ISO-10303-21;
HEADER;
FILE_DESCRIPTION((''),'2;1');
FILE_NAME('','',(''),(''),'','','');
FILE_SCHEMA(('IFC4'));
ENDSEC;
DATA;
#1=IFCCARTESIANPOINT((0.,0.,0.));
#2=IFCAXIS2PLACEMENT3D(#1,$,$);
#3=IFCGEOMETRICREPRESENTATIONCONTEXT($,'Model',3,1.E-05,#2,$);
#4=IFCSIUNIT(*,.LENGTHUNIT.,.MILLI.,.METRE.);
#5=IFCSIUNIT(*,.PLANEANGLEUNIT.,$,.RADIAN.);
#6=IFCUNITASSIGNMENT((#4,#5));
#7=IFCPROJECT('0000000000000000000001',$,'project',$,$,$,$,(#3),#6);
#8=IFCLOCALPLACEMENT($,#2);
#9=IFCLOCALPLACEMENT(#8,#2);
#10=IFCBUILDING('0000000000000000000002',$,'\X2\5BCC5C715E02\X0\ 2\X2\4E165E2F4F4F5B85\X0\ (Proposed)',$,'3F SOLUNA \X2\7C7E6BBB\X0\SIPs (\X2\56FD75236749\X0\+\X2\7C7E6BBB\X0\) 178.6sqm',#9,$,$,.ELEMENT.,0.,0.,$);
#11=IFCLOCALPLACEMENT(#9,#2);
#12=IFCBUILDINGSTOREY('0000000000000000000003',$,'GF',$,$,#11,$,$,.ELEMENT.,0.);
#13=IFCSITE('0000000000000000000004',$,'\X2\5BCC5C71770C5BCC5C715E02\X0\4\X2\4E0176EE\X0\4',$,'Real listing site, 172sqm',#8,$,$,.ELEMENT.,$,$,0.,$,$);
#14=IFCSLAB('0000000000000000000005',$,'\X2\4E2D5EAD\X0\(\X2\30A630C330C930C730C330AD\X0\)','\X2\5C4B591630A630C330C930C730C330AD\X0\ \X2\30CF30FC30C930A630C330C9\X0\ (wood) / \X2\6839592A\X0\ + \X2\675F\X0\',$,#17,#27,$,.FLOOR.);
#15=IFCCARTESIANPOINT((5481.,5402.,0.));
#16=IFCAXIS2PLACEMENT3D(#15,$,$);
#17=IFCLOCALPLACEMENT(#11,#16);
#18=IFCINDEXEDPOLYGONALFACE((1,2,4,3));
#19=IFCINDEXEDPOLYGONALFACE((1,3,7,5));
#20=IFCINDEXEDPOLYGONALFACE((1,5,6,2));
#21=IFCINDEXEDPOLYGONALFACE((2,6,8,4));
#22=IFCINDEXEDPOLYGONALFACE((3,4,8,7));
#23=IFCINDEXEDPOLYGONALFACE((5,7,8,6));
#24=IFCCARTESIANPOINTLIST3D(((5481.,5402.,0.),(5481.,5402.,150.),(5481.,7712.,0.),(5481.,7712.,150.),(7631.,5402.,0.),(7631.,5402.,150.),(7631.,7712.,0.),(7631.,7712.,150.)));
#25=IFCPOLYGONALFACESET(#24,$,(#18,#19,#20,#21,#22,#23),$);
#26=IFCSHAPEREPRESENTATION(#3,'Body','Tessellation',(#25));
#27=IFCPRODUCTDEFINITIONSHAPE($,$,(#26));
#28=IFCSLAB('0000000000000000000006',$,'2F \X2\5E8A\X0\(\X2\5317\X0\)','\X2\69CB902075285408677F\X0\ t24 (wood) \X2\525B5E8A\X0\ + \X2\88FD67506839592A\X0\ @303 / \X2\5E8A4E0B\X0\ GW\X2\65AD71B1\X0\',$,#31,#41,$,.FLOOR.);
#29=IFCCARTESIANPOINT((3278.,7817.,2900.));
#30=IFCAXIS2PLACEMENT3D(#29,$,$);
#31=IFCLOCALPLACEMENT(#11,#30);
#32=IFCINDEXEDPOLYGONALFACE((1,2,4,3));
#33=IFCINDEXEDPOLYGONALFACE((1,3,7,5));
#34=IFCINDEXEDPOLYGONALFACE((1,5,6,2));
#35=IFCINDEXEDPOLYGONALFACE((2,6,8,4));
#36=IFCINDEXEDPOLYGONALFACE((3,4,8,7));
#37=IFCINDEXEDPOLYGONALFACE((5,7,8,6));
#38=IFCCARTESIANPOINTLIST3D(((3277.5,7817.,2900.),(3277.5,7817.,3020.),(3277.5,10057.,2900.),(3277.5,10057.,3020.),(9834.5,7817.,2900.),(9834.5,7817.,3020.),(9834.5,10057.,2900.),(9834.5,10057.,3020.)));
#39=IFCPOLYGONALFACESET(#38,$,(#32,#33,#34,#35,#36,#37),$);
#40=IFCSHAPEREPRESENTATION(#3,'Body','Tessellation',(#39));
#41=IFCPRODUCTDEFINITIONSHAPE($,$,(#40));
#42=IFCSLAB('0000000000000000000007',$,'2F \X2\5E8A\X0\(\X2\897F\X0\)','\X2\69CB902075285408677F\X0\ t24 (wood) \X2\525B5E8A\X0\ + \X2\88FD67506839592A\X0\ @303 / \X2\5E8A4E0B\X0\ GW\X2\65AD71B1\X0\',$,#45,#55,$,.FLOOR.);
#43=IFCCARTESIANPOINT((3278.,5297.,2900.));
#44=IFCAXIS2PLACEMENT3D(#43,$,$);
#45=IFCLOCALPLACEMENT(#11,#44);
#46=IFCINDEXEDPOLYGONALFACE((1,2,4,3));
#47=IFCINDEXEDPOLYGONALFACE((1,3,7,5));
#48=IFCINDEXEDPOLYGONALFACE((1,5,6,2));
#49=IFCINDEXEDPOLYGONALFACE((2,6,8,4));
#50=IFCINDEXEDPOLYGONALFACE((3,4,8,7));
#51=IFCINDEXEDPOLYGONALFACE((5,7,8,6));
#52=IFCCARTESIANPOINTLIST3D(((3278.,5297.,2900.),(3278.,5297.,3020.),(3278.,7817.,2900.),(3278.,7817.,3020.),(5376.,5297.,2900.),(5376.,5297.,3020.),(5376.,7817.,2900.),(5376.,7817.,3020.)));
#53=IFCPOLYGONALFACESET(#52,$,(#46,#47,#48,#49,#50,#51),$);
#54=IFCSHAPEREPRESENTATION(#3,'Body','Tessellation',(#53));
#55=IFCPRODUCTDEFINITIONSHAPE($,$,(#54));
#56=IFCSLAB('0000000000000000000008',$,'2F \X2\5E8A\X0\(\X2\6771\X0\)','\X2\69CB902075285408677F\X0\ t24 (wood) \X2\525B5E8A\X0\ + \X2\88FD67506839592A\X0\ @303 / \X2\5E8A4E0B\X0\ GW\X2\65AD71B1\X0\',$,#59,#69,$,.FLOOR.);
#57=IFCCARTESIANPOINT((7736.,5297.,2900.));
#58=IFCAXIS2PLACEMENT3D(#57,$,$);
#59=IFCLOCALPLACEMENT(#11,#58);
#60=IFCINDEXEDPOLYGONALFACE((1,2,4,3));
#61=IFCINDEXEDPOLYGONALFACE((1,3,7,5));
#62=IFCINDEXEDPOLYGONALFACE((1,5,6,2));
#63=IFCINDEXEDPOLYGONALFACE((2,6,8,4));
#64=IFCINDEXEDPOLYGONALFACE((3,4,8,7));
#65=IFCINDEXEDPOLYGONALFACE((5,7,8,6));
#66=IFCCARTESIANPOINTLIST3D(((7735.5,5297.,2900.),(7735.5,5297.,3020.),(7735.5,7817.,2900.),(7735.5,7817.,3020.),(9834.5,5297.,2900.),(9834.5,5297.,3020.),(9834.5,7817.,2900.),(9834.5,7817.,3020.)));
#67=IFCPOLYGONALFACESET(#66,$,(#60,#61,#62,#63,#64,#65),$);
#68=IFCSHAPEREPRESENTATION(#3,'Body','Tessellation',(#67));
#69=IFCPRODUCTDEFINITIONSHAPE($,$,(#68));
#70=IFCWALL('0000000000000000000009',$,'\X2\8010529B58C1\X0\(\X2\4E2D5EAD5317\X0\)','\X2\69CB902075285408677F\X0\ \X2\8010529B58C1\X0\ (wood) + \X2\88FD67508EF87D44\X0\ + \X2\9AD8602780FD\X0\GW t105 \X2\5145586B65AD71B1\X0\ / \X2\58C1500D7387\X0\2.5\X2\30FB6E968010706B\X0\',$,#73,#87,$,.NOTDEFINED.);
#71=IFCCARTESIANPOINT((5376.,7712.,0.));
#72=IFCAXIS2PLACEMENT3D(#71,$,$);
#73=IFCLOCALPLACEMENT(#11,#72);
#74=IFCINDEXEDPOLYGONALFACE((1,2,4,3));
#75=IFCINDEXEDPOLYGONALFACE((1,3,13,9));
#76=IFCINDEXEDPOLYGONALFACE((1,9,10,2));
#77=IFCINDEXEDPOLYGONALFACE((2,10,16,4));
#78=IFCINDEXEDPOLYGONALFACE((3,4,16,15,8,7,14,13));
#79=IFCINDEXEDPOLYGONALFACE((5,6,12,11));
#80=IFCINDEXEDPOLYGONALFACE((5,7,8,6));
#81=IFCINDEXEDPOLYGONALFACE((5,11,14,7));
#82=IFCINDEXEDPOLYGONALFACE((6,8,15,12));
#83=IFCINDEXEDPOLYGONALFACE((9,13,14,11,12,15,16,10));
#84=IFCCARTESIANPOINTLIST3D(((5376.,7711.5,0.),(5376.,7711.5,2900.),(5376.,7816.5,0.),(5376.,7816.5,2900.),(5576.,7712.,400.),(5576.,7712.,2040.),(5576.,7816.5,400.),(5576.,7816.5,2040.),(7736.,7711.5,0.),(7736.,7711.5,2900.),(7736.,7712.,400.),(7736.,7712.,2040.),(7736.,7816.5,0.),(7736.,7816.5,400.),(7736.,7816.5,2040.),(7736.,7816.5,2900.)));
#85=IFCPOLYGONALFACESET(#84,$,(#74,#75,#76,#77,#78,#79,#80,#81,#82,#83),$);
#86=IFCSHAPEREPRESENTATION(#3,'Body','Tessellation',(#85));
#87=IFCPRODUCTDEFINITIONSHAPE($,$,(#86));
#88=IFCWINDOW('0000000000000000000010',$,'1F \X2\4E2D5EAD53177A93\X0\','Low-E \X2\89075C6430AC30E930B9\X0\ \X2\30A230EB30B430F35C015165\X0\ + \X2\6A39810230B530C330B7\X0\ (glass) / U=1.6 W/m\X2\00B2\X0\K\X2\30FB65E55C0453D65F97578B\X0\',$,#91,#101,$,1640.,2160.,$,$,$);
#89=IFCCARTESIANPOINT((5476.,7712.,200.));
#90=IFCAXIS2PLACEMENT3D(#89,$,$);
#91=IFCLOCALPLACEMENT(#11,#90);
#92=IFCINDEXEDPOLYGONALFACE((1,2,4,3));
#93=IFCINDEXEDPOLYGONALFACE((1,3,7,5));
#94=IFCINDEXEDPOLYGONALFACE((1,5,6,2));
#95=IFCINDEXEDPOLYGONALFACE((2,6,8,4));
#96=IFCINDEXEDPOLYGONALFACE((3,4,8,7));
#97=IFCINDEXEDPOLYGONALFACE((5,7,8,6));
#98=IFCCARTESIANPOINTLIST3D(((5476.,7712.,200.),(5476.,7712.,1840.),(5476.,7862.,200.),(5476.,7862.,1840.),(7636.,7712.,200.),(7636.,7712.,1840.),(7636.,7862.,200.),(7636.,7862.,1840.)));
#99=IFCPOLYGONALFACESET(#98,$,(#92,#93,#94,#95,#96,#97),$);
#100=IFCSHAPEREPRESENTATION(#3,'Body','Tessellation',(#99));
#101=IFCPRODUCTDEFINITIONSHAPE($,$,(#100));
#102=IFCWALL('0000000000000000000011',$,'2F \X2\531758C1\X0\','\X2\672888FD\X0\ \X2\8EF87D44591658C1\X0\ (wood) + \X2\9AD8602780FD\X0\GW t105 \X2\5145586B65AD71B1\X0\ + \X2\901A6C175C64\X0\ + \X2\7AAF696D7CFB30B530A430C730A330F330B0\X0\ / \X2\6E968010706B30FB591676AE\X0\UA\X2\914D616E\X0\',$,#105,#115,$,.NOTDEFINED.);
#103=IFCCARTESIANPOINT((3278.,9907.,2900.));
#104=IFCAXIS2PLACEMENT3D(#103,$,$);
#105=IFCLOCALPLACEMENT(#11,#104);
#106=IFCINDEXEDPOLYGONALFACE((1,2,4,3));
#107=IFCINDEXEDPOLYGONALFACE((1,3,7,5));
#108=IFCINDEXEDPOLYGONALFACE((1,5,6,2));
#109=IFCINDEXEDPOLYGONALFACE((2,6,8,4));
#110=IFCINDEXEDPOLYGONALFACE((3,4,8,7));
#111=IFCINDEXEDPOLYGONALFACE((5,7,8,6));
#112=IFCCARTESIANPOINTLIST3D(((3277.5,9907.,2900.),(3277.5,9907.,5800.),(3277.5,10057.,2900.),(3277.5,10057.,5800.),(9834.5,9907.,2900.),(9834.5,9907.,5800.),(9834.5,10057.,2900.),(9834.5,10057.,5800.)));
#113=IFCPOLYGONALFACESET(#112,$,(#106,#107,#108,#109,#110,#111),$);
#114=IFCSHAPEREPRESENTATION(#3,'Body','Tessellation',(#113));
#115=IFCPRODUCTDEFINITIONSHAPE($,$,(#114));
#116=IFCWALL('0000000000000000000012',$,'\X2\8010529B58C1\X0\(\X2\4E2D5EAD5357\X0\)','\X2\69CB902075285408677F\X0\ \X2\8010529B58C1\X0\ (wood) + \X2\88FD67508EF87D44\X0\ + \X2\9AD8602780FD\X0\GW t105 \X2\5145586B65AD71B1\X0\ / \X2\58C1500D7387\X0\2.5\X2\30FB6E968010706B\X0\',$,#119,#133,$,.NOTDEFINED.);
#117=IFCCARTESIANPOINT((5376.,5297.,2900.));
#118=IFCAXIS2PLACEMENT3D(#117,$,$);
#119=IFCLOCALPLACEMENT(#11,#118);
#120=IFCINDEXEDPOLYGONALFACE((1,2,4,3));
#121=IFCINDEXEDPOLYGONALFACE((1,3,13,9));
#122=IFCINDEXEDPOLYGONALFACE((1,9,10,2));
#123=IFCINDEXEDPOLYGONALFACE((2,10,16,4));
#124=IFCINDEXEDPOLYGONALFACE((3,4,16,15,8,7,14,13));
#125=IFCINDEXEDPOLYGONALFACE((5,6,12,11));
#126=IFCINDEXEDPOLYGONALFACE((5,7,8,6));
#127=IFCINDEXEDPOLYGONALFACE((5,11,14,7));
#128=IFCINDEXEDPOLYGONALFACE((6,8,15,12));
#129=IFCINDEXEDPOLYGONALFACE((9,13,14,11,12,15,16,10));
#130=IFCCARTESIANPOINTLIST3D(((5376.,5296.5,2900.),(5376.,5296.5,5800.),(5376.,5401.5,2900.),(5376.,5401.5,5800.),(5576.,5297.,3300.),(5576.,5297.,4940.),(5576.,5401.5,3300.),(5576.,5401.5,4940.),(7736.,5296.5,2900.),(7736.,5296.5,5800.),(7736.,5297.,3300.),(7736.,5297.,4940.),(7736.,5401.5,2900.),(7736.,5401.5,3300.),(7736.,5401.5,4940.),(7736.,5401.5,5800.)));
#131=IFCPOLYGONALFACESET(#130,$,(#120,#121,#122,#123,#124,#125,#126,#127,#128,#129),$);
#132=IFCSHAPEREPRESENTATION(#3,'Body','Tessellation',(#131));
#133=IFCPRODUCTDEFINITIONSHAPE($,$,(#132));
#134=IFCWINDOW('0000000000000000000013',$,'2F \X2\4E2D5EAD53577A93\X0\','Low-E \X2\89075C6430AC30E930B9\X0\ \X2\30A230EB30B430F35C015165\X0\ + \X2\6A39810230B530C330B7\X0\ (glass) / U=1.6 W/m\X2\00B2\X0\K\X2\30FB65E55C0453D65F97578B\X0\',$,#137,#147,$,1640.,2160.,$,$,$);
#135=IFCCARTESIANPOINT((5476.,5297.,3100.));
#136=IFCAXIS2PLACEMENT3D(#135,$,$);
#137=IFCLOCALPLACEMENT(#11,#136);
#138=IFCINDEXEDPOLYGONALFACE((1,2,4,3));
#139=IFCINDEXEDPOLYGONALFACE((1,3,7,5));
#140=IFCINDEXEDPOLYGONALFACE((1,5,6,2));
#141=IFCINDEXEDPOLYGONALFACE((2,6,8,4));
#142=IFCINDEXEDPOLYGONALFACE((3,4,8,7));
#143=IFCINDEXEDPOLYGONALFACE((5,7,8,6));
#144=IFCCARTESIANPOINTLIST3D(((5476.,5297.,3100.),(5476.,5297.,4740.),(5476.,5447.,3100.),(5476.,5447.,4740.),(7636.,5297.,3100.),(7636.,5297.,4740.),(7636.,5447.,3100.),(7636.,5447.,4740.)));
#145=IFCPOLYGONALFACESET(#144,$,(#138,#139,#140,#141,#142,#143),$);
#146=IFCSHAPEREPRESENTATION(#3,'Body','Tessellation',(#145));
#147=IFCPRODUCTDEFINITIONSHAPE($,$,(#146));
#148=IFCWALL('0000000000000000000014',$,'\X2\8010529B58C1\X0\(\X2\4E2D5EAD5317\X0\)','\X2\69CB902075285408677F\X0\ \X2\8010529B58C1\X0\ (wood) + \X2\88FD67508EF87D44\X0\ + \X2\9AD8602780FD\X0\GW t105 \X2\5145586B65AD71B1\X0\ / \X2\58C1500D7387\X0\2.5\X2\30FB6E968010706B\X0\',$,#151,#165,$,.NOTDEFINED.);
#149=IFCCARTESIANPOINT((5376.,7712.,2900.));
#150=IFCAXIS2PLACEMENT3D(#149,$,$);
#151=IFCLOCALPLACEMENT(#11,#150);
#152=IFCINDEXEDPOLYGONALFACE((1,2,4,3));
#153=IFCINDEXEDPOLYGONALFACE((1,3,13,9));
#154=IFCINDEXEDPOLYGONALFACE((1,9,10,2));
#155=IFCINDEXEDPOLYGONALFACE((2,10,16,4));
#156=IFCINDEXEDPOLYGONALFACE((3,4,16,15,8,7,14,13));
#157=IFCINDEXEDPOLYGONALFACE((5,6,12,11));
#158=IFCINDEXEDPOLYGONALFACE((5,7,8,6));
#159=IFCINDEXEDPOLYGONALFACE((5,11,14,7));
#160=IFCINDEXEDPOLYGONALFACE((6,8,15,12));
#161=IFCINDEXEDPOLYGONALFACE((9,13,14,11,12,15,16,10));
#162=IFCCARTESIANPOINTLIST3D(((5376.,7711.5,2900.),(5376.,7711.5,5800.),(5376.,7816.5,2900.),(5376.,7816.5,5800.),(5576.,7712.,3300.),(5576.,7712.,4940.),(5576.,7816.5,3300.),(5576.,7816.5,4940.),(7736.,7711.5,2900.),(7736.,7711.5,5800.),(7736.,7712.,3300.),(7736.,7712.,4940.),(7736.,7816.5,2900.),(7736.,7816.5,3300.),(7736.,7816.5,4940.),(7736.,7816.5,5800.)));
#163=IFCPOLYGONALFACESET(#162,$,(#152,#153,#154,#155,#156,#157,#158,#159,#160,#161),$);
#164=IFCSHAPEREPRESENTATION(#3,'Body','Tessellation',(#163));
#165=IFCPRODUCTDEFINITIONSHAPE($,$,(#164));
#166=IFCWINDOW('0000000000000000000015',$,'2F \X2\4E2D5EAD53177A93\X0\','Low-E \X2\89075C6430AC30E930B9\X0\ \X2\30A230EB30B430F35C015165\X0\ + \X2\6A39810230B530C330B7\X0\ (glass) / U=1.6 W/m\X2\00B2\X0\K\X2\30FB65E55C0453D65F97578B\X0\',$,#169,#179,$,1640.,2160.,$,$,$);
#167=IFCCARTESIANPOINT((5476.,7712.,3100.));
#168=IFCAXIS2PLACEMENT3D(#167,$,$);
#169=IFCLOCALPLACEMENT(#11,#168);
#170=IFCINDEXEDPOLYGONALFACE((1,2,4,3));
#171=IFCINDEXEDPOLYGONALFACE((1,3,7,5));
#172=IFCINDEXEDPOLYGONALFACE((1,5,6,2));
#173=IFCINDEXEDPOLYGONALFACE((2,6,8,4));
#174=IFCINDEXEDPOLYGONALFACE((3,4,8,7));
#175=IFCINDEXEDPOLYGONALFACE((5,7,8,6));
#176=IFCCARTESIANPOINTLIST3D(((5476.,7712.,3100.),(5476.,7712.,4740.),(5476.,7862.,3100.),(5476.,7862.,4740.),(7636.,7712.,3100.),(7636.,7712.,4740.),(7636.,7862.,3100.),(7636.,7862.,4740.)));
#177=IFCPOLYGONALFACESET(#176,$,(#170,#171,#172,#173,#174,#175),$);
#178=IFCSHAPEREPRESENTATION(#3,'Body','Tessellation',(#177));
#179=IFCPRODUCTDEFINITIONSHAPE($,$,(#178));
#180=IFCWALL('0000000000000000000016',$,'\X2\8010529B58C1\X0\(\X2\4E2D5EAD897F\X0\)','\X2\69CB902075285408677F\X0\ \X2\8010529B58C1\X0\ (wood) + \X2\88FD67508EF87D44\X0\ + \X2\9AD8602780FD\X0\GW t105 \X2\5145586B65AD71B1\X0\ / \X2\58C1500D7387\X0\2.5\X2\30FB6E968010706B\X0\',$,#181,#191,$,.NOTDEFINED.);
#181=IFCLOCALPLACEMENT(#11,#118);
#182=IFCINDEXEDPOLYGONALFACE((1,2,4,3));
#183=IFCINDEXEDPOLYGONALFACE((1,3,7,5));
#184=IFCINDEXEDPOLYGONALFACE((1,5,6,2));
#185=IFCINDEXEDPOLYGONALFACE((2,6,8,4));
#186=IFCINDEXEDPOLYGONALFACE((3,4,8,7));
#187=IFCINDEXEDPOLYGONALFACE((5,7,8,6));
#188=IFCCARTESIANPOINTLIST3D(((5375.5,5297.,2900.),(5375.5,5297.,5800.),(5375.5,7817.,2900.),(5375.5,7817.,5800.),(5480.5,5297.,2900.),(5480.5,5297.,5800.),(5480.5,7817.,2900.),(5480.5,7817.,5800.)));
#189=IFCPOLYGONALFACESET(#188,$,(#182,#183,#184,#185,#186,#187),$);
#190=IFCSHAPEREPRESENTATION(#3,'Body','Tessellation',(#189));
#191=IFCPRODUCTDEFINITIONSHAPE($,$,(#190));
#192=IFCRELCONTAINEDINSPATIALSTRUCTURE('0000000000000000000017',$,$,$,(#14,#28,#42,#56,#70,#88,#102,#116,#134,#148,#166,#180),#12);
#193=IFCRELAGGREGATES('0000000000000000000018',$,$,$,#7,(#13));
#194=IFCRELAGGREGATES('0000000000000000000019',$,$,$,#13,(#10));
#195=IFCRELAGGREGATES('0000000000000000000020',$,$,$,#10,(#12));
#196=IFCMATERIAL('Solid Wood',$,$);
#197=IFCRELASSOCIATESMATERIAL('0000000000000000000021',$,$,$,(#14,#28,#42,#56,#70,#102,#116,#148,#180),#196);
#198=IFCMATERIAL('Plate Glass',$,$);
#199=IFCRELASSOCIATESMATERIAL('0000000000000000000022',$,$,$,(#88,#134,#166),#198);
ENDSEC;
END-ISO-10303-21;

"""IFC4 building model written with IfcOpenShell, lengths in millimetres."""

from ifc_helpers import new_model, si_unit, frame, frame_2d, origin, place, context, project, spatial, rectangle, extrude, material, element, fill, save


model = new_model("IFC4")

# Units and contexts
model_context = context("Model", 3, precision=1e-05, world=origin())
ifc_project = project(units=[si_unit("LENGTHUNIT", "METRE", prefix="MILLI"), si_unit("PLANEANGLEUNIT", "RADIAN")], contexts=[model_context])

# Site, building, storey
site_placement = place(None, origin())
site = spatial("IfcSite", under=ifc_project, at=site_placement, Name="富山県富山市4丁目4", ObjectType="Real listing site, 172sqm", CompositionType="ELEMENT", RefElevation=0.0)
building_placement = place(site_placement, origin())
building = spatial("IfcBuilding", under=site, at=building_placement, Name="富山市 2世帯住宅 (Proposed)", ObjectType="3F SOLUNA 籾殻SIPs (国産杉+籾殻) 178.6sqm", CompositionType="ELEMENT", ElevationOfRefHeight=0.0, ElevationOfTerrain=0.0)
storey_placement = place(building_placement, origin())
storey = spatial("IfcBuildingStorey", under=building, at=storey_placement, Name="GF", CompositionType="ELEMENT", Elevation=0.0)

# Slabs
ifc_material_1 = material(Name="Solid Wood")
slab_1_placement = place(storey_placement, frame((5481.0, 5402.0, 0.0)))
element("IfcSlab", 1, at=slab_1_placement, inside=storey, material=ifc_material_1, Name="中庭(ウッドデッキ)", Description="屋外ウッドデッキ ハードウッド (wood) / 根太 + 束", PredefinedType="FLOOR", context=model_context, shape_type="SweptSolid", body=[
    extrude(rectangle(XDim=2150.0, YDim=2310.0, at=frame_2d((1075.0, 1155.0))), frame((5481.0, 5402.0, 0.0)), (0.0, 0.0, 1.0), 150.0),
])
slab_2_placement = place(storey_placement, frame((3278.0, 7817.0, 2900.0)))
element("IfcSlab", 2, at=slab_2_placement, inside=storey, material=ifc_material_1, Name="2F 床(北)", Description="構造用合板 t24 (wood) 剛床 + 製材根太 @303 / 床下 GW断熱", PredefinedType="FLOOR", context=model_context, shape_type="SweptSolid", body=[
    extrude(rectangle(XDim=6557.0, YDim=2240.0, at=frame_2d((3278.0, 1120.0))), frame((3278.0, 7817.0, 2900.0)), (0.0, 0.0, 1.0), 120.0),
])
slab_3_placement = place(storey_placement, frame((3278.0, 5297.0, 2900.0)))
element("IfcSlab", 3, at=slab_3_placement, inside=storey, material=ifc_material_1, Name="2F 床(西)", Description="構造用合板 t24 (wood) 剛床 + 製材根太 @303 / 床下 GW断熱", PredefinedType="FLOOR", context=model_context, shape_type="SweptSolid", body=[
    extrude(rectangle(XDim=2098.0, YDim=2520.0, at=frame_2d((1049.0, 1260.0))), frame((3278.0, 5297.0, 2900.0)), (0.0, 0.0, 1.0), 120.0),
])
slab_4_placement = place(storey_placement, frame((7736.0, 5297.0, 2900.0)))
element("IfcSlab", 4, at=slab_4_placement, inside=storey, material=ifc_material_1, Name="2F 床(東)", Description="構造用合板 t24 (wood) 剛床 + 製材根太 @303 / 床下 GW断熱", PredefinedType="FLOOR", context=model_context, shape_type="SweptSolid", body=[
    extrude(rectangle(XDim=2099.0, YDim=2520.0, at=frame_2d((1049.0, 1260.0))), frame((7736.0, 5297.0, 2900.0)), (0.0, 0.0, 1.0), 120.0),
])

# Wall, opening, window
wall_1_placement = place(storey_placement, frame((5376.0, 7712.0, 0.0)))
wall_1 = element("IfcWall", 5, at=wall_1_placement, inside=storey, material=ifc_material_1, Name="耐力壁(中庭北)", Description="構造用合板 耐力壁 (wood) + 製材軸組 + 高性能GW t105 充填断熱 / 壁倍率2.5・準耐火", PredefinedType="NOTDEFINED", context=model_context, shape_type="SweptSolid", body=[
    extrude(rectangle(XDim=2360.0, YDim=105.0, at=frame_2d((1180.0, 52.0))), frame((5376.0, 7712.0, 0.0)), (0.0, 0.0, 1.0), 2900.0),
])
opening_1_placement = place(storey_placement, frame((5476.0, 7712.0, 200.0)))
opening_1 = element("IfcOpeningElement", 6, at=opening_1_placement, cuts=wall_1, PredefinedType="NOTDEFINED", context=model_context, shape_type="SweptSolid", body=[
    extrude(rectangle(XDim=2160.0, YDim=150.0, at=frame_2d((1080.0, 75.0))), frame((5476.0, 7712.0, 200.0)), (0.0, 0.0, 1.0), 1640.0),
])
ifc_material_2 = material(Name="Plate Glass")
window_1_placement = place(storey_placement, frame((5476.0, 7712.0, 200.0)))
window_1 = element("IfcWindow", 7, at=window_1_placement, inside=storey, material=ifc_material_2, Name="1F 中庭北窓", Description="Low-E 複層ガラス アルゴン封入 + 樹脂サッシ (glass) / U=1.6 W/m²K・日射取得型", OverallHeight=1640.0, OverallWidth=2160.0, context=model_context, shape_type="SweptSolid", body=[
    extrude(rectangle(XDim=2160.0, YDim=150.0, at=frame_2d((1080.0, 75.0))), frame((5476.0, 7712.0, 200.0)), (0.0, 0.0, 1.0), 1640.0),
])
fill(opening_1, window_1)

# Wall
wall_2_placement = place(storey_placement, frame((3278.0, 9907.0, 2900.0)))
element("IfcWall", 8, at=wall_2_placement, inside=storey, material=ifc_material_1, Name="2F 北壁", Description="木製 軸組外壁 (wood) + 高性能GW t105 充填断熱 + 通気層 + 窯業系サイディング / 準耐火・外皮UA配慮", PredefinedType="NOTDEFINED", context=model_context, shape_type="SweptSolid", body=[
    extrude(rectangle(XDim=6557.0, YDim=150.0, at=frame_2d((3278.0, 75.0))), frame((3278.0, 9907.0, 2900.0)), (0.0, 0.0, 1.0), 2900.0),
])

# Walls, openings, windows
wall_3_placement = place(storey_placement, frame((5376.0, 5297.0, 2900.0)))
wall_3 = element("IfcWall", 9, at=wall_3_placement, inside=storey, material=ifc_material_1, Name="耐力壁(中庭南)", Description="構造用合板 耐力壁 (wood) + 製材軸組 + 高性能GW t105 充填断熱 / 壁倍率2.5・準耐火", PredefinedType="NOTDEFINED", context=model_context, shape_type="SweptSolid", body=[
    extrude(rectangle(XDim=2360.0, YDim=105.0, at=frame_2d((1180.0, 52.0))), frame((5376.0, 5297.0, 2900.0)), (0.0, 0.0, 1.0), 2900.0),
])
opening_2_placement = place(storey_placement, frame((5476.0, 5297.0, 3100.0)))
opening_2 = element("IfcOpeningElement", 10, at=opening_2_placement, cuts=wall_3, PredefinedType="NOTDEFINED", context=model_context, shape_type="SweptSolid", body=[
    extrude(rectangle(XDim=2160.0, YDim=150.0, at=frame_2d((1080.0, 75.0))), frame((5476.0, 5297.0, 3100.0)), (0.0, 0.0, 1.0), 1640.0),
])
window_2_placement = place(storey_placement, frame((5476.0, 5297.0, 3100.0)))
window_2 = element("IfcWindow", 11, at=window_2_placement, inside=storey, material=ifc_material_2, Name="2F 中庭南窓", Description="Low-E 複層ガラス アルゴン封入 + 樹脂サッシ (glass) / U=1.6 W/m²K・日射取得型", OverallHeight=1640.0, OverallWidth=2160.0, context=model_context, shape_type="SweptSolid", body=[
    extrude(rectangle(XDim=2160.0, YDim=150.0, at=frame_2d((1080.0, 75.0))), frame((5476.0, 5297.0, 3100.0)), (0.0, 0.0, 1.0), 1640.0),
])
fill(opening_2, window_2)
wall_4_placement = place(storey_placement, frame((5376.0, 7712.0, 2900.0)))
wall_4 = element("IfcWall", 12, at=wall_4_placement, inside=storey, material=ifc_material_1, Name="耐力壁(中庭北)", Description="構造用合板 耐力壁 (wood) + 製材軸組 + 高性能GW t105 充填断熱 / 壁倍率2.5・準耐火", PredefinedType="NOTDEFINED", context=model_context, shape_type="SweptSolid", body=[
    extrude(rectangle(XDim=2360.0, YDim=105.0, at=frame_2d((1180.0, 52.0))), frame((5376.0, 7712.0, 2900.0)), (0.0, 0.0, 1.0), 2900.0),
])
opening_3_placement = place(storey_placement, frame((5476.0, 7712.0, 3100.0)))
opening_3 = element("IfcOpeningElement", 13, at=opening_3_placement, cuts=wall_4, PredefinedType="NOTDEFINED", context=model_context, shape_type="SweptSolid", body=[
    extrude(rectangle(XDim=2160.0, YDim=150.0, at=frame_2d((1080.0, 75.0))), frame((5476.0, 7712.0, 3100.0)), (0.0, 0.0, 1.0), 1640.0),
])
window_3_placement = place(storey_placement, frame((5476.0, 7712.0, 3100.0)))
window_3 = element("IfcWindow", 14, at=window_3_placement, inside=storey, material=ifc_material_2, Name="2F 中庭北窓", Description="Low-E 複層ガラス アルゴン封入 + 樹脂サッシ (glass) / U=1.6 W/m²K・日射取得型", OverallHeight=1640.0, OverallWidth=2160.0, context=model_context, shape_type="SweptSolid", body=[
    extrude(rectangle(XDim=2160.0, YDim=150.0, at=frame_2d((1080.0, 75.0))), frame((5476.0, 7712.0, 3100.0)), (0.0, 0.0, 1.0), 1640.0),
])
fill(opening_3, window_3)

# Wall
wall_5_placement = place(storey_placement, frame((5376.0, 5297.0, 2900.0)))
element("IfcWall", 15, at=wall_5_placement, inside=storey, material=ifc_material_1, Name="耐力壁(中庭西)", Description="構造用合板 耐力壁 (wood) + 製材軸組 + 高性能GW t105 充填断熱 / 壁倍率2.5・準耐火", PredefinedType="NOTDEFINED", context=model_context, shape_type="SweptSolid", body=[
    extrude(rectangle(XDim=105.0, YDim=2520.0, at=frame_2d((52.0, 1260.0))), frame((5376.0, 5297.0, 2900.0)), (0.0, 0.0, 1.0), 2900.0),
])

save(model, "model.ifc")
